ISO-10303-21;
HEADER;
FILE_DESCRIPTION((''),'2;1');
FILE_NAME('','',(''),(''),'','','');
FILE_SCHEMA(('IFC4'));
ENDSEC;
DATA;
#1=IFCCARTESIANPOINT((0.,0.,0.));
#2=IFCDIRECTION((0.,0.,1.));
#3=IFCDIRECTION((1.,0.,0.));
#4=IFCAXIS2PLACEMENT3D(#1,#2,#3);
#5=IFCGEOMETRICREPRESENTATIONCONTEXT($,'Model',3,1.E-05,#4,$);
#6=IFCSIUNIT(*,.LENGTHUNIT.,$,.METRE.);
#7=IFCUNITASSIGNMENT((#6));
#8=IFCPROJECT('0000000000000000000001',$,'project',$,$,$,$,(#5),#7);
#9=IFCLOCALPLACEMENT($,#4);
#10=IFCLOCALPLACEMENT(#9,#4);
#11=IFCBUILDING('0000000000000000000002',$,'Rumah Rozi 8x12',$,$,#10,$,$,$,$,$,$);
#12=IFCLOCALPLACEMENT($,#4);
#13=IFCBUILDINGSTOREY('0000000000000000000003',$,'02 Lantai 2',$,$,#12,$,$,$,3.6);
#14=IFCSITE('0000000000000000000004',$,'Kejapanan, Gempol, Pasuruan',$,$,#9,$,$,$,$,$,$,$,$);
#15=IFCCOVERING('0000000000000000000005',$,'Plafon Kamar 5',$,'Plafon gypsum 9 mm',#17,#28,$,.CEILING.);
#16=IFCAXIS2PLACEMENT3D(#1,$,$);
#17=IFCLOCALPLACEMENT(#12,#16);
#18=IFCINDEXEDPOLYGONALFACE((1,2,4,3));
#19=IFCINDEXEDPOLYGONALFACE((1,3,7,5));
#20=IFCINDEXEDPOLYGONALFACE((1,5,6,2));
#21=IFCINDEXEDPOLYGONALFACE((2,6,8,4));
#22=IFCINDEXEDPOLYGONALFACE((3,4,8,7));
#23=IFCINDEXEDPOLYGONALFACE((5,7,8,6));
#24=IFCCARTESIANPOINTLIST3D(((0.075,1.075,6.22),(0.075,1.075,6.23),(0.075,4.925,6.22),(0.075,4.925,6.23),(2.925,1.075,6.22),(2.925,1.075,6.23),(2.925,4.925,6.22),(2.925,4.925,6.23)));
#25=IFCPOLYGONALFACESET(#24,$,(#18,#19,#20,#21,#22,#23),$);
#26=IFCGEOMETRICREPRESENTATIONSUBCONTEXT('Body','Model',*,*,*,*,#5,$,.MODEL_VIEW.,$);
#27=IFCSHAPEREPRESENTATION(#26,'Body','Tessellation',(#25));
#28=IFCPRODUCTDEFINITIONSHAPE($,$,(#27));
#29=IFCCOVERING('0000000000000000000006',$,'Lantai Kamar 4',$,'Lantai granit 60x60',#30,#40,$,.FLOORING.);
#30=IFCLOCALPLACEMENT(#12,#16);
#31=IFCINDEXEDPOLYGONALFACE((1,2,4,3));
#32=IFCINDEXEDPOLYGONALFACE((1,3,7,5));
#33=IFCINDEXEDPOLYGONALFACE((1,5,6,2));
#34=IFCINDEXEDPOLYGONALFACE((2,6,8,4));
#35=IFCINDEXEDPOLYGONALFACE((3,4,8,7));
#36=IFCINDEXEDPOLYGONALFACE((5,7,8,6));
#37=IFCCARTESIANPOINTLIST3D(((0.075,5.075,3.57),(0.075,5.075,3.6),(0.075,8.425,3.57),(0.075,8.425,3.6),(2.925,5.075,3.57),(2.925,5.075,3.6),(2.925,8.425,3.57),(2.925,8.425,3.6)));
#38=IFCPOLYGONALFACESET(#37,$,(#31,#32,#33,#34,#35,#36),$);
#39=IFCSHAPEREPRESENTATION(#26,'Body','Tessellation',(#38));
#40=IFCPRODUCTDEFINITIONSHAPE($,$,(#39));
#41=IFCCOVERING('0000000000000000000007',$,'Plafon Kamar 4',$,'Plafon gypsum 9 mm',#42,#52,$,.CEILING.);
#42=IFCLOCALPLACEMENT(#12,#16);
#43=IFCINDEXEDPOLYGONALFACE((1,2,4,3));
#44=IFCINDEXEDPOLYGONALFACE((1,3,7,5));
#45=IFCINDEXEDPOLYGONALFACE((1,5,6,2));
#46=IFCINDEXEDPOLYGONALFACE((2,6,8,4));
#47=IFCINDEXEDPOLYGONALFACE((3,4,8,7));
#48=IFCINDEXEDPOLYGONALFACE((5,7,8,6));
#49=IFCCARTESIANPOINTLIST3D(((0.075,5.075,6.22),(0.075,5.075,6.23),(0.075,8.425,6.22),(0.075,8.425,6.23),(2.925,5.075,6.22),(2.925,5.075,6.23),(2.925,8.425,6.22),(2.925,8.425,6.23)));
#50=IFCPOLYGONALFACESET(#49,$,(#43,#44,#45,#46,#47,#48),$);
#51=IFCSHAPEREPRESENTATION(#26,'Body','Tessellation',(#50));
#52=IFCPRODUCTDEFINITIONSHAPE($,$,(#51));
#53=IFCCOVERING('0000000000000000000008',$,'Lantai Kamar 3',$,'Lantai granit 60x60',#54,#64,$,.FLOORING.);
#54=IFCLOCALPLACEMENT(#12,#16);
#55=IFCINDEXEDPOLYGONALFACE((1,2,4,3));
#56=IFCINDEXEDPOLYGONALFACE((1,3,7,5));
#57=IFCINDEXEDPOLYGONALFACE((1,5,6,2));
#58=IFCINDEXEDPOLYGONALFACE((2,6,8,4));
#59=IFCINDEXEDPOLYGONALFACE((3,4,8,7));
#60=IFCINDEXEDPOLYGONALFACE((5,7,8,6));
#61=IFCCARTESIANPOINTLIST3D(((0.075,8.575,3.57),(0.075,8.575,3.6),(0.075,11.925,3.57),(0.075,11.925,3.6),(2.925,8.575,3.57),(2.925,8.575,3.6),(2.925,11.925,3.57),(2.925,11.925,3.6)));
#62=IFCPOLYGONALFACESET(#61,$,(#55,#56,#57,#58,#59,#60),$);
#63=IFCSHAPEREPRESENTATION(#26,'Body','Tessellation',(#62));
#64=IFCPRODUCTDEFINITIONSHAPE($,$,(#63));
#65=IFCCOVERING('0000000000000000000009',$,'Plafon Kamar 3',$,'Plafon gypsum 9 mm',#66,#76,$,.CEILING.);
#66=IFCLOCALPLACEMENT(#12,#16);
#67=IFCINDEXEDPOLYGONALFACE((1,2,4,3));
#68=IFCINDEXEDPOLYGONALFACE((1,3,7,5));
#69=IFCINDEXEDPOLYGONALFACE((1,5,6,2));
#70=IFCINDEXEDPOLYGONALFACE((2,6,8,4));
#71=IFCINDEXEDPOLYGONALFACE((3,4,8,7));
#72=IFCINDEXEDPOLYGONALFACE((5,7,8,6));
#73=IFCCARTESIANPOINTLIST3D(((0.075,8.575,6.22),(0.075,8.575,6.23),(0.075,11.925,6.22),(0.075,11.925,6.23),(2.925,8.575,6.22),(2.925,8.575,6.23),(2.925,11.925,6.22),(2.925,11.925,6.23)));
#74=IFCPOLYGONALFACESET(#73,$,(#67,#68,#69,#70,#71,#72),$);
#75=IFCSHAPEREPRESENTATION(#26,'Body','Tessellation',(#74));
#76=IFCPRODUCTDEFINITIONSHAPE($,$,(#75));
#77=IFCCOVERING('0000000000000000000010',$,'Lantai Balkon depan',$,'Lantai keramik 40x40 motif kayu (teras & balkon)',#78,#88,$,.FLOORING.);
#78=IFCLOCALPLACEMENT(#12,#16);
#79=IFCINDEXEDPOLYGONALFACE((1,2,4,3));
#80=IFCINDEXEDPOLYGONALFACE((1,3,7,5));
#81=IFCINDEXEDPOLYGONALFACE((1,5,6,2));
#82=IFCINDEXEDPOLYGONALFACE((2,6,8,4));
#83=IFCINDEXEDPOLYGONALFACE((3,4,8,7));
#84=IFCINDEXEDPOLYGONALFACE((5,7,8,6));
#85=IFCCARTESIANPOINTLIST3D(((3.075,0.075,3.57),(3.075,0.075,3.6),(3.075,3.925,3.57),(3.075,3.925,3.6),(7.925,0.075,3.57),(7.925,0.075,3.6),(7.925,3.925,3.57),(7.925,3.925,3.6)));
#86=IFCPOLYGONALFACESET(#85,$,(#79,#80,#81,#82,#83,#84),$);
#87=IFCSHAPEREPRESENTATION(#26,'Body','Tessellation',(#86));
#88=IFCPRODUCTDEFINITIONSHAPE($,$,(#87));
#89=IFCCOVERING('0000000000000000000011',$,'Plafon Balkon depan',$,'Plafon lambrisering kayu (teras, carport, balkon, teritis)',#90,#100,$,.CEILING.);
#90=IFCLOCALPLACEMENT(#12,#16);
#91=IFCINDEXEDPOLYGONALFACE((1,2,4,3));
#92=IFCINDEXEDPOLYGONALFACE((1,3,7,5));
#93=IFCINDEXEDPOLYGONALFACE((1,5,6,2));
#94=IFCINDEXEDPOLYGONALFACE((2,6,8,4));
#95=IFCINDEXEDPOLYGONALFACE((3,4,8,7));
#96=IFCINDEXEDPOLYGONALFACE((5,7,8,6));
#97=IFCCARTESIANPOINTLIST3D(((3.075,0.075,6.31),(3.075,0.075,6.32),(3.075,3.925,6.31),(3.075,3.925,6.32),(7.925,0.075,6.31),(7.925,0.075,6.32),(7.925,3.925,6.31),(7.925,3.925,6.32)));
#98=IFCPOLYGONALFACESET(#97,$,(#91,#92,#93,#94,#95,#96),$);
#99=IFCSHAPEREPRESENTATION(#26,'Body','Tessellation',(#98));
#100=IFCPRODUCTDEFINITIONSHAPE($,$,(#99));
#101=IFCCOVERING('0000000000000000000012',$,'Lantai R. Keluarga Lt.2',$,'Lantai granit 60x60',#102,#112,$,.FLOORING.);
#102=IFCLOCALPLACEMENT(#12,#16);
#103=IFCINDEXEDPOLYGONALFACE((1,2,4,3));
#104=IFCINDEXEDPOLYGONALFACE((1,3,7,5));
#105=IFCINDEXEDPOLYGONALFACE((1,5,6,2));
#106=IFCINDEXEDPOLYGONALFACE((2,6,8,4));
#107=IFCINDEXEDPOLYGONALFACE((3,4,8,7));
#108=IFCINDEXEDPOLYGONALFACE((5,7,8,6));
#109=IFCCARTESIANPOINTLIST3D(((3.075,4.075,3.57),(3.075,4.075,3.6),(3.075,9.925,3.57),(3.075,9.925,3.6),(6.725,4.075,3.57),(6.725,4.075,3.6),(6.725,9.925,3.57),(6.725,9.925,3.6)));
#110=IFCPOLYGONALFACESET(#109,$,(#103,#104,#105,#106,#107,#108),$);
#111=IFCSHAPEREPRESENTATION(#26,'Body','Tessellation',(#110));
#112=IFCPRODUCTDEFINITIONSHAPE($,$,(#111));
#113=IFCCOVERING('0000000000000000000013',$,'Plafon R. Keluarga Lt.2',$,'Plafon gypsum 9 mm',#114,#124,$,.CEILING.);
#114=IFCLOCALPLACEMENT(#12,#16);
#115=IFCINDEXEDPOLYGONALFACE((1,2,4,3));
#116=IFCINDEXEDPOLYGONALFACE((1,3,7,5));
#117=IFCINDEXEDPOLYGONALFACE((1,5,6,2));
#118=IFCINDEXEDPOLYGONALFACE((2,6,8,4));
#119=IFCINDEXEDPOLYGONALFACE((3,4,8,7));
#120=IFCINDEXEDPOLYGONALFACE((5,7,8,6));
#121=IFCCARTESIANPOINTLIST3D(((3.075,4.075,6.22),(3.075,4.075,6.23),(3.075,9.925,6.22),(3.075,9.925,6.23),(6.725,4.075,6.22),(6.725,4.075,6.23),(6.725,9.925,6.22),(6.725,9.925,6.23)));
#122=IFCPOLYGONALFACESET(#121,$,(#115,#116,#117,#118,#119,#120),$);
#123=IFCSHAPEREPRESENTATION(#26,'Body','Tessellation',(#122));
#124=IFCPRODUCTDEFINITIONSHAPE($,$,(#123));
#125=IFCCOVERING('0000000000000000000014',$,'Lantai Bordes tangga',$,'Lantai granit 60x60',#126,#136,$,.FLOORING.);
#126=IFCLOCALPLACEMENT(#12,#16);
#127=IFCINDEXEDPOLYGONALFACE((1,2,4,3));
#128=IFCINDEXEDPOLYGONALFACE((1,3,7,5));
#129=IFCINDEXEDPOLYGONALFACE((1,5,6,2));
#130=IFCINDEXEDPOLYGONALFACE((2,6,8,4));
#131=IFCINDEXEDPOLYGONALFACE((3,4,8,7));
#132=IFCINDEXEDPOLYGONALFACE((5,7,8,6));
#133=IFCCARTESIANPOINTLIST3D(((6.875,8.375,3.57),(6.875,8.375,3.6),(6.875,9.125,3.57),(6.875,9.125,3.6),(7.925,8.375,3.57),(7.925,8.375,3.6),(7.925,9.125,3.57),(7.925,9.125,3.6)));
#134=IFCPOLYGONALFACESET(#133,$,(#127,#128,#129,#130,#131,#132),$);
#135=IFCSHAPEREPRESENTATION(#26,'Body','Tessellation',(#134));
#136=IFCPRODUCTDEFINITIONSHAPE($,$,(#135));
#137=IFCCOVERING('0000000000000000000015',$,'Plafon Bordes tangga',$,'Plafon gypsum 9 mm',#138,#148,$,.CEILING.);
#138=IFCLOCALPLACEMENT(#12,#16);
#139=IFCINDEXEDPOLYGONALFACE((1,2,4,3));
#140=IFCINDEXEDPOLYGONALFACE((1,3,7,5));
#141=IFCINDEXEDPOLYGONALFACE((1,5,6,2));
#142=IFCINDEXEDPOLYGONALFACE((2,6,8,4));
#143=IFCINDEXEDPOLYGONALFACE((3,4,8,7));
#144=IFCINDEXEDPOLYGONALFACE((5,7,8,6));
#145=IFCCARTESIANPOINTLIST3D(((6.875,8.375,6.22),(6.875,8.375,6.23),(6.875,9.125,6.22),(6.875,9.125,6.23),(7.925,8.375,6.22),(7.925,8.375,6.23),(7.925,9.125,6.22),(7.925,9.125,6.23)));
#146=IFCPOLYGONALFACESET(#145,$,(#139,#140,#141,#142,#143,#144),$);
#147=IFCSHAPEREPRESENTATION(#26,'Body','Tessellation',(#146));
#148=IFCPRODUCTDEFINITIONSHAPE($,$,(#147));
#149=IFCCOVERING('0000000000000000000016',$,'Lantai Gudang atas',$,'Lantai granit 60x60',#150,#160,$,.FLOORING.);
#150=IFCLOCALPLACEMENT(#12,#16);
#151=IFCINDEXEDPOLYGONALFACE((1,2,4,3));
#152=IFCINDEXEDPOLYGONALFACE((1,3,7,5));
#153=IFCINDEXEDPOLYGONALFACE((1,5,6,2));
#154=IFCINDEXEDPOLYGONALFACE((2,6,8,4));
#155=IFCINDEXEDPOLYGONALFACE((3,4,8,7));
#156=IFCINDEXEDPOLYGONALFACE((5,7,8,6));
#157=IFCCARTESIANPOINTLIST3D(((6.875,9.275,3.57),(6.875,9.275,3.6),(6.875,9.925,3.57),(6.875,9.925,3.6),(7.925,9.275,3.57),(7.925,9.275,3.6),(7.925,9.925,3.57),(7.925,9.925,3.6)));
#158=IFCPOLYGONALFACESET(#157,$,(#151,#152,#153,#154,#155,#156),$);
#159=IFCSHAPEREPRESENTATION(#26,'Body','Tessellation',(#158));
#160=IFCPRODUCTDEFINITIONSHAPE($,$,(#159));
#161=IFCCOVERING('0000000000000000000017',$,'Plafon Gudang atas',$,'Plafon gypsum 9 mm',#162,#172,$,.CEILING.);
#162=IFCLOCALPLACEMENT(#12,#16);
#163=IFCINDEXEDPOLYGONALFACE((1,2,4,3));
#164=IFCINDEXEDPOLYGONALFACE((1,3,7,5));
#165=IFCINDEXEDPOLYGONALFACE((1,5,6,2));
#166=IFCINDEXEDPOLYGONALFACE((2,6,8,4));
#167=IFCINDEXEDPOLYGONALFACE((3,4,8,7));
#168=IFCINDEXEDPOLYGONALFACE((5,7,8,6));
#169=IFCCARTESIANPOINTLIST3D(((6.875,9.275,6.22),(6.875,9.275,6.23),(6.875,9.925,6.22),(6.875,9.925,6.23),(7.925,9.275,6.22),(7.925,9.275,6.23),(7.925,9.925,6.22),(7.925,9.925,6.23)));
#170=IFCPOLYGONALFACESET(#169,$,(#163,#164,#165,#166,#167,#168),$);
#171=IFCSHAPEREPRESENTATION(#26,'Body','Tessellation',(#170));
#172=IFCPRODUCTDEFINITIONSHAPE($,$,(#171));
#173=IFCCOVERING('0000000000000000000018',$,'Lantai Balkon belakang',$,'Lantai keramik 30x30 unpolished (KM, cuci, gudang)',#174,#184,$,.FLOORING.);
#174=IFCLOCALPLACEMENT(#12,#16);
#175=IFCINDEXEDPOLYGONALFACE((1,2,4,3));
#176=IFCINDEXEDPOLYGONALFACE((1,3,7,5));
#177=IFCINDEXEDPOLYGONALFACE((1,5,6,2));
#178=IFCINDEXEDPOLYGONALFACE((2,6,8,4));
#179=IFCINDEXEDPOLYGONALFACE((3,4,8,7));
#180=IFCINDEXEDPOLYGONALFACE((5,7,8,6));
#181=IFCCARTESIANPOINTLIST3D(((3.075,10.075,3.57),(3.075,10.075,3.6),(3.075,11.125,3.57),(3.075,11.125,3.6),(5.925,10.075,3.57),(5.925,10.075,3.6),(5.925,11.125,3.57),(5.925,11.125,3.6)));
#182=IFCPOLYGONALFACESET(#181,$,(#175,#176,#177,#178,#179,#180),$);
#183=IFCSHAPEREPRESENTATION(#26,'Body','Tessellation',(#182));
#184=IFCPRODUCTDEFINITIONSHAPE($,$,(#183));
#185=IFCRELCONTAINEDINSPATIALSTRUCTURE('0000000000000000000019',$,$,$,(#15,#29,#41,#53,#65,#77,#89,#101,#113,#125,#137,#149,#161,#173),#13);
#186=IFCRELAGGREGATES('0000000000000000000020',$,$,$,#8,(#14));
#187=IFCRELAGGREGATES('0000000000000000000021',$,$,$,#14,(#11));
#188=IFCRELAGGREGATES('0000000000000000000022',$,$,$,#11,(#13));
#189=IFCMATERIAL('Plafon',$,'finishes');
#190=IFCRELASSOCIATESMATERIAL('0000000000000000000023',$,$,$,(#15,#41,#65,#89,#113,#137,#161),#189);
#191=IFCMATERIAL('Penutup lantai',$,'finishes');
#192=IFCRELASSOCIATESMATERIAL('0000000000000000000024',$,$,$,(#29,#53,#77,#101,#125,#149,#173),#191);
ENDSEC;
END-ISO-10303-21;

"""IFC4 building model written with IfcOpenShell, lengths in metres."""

from ifc_helpers import new_model, si_unit, frame, origin_with_axes, place, context, subcontext, project, spatial, line, indexed_curve, outline, extrude, material, element, save


model = new_model("IFC4")

# Units and contexts
model_context = context("Model", 3, precision=1e-05, world=origin_with_axes())
body_context = subcontext(model_context, "Body", "Model", "MODEL_VIEW")
ifc_project = project(units=[si_unit("LENGTHUNIT", "METRE")], contexts=[model_context])

# Site, building, storey
site_placement = place(None, origin_with_axes())
site = spatial("IfcSite", under=ifc_project, at=site_placement, Name="Kejapanan, Gempol, Pasuruan")
building_placement = place(site_placement, origin_with_axes())
building = spatial("IfcBuilding", under=site, at=building_placement, Name="Rumah Rozi 8x12")
storey_placement = place(None, origin_with_axes())
storey = spatial("IfcBuildingStorey", under=building, at=storey_placement, Name="02 Lantai 2", Elevation=3.6)

# Coverings
ifc_material_1 = material(Name="Plafon", Category="finishes")
covering_1_placement = place(storey_placement, origin_with_axes())
element("IfcCovering", 1, at=covering_1_placement, inside=storey, material=ifc_material_1, Name="Plafon Kamar 5", ObjectType="Plafon gypsum 9 mm", PredefinedType="CEILING", context=body_context, shape_type="SweptSolid", body=[
    extrude(outline(indexed_curve([(0.075, 1.075), (2.925, 1.075), (2.925, 4.925), (0.075, 4.925)], segments=[line(1, 2, 3, 4, 1)])), frame((0.0, 0.0, 6.22), z_axis=(0.0, 0.0, 1.0), x_axis=(1.0, 0.0, 0.0)), (0.0, 0.0, 1.0), 0.01),
])
ifc_material_2 = material(Name="Penutup lantai", Category="finishes")
covering_2_placement = place(storey_placement, origin_with_axes())
element("IfcCovering", 2, at=covering_2_placement, inside=storey, material=ifc_material_2, Name="Lantai Kamar 4", ObjectType="Lantai granit 60x60", PredefinedType="FLOORING", context=body_context, shape_type="SweptSolid", body=[
    extrude(outline(indexed_curve([(0.075, 5.075), (2.925, 5.075), (2.925, 8.425), (0.075, 8.425)], segments=[line(1, 2, 3, 4, 1)])), frame((0.0, 0.0, 3.57), z_axis=(0.0, 0.0, 1.0), x_axis=(1.0, 0.0, 0.0)), (0.0, 0.0, 1.0), 0.03),
])
covering_3_placement = place(storey_placement, origin_with_axes())
element("IfcCovering", 3, at=covering_3_placement, inside=storey, material=ifc_material_1, Name="Plafon Kamar 4", ObjectType="Plafon gypsum 9 mm", PredefinedType="CEILING", context=body_context, shape_type="SweptSolid", body=[
    extrude(outline(indexed_curve([(0.075, 5.075), (2.925, 5.075), (2.925, 8.425), (0.075, 8.425)], segments=[line(1, 2, 3, 4, 1)])), frame((0.0, 0.0, 6.22), z_axis=(0.0, 0.0, 1.0), x_axis=(1.0, 0.0, 0.0)), (0.0, 0.0, 1.0), 0.01),
])
covering_4_placement = place(storey_placement, origin_with_axes())
element("IfcCovering", 4, at=covering_4_placement, inside=storey, material=ifc_material_2, Name="Lantai Kamar 3", ObjectType="Lantai granit 60x60", PredefinedType="FLOORING", context=body_context, shape_type="SweptSolid", body=[
    extrude(outline(indexed_curve([(0.075, 8.575), (2.925, 8.575), (2.925, 11.925), (0.075, 11.925)], segments=[line(1, 2, 3, 4, 1)])), frame((0.0, 0.0, 3.57), z_axis=(0.0, 0.0, 1.0), x_axis=(1.0, 0.0, 0.0)), (0.0, 0.0, 1.0), 0.03),
])
covering_5_placement = place(storey_placement, origin_with_axes())
element("IfcCovering", 5, at=covering_5_placement, inside=storey, material=ifc_material_1, Name="Plafon Kamar 3", ObjectType="Plafon gypsum 9 mm", PredefinedType="CEILING", context=body_context, shape_type="SweptSolid", body=[
    extrude(outline(indexed_curve([(0.075, 8.575), (2.925, 8.575), (2.925, 11.925), (0.075, 11.925)], segments=[line(1, 2, 3, 4, 1)])), frame((0.0, 0.0, 6.22), z_axis=(0.0, 0.0, 1.0), x_axis=(1.0, 0.0, 0.0)), (0.0, 0.0, 1.0), 0.01),
])
covering_6_placement = place(storey_placement, origin_with_axes())
element("IfcCovering", 6, at=covering_6_placement, inside=storey, material=ifc_material_2, Name="Lantai Balkon depan", ObjectType="Lantai keramik 40x40 motif kayu (teras & balkon)", PredefinedType="FLOORING", context=body_context, shape_type="SweptSolid", body=[
    extrude(outline(indexed_curve([(3.075, 0.075), (7.925, 0.075), (7.925, 3.925), (3.075, 3.925)], segments=[line(1, 2, 3, 4, 1)])), frame((0.0, 0.0, 3.57), z_axis=(0.0, 0.0, 1.0), x_axis=(1.0, 0.0, 0.0)), (0.0, 0.0, 1.0), 0.03),
])
covering_7_placement = place(storey_placement, origin_with_axes())
element("IfcCovering", 7, at=covering_7_placement, inside=storey, material=ifc_material_1, Name="Plafon Balkon depan", ObjectType="Plafon lambrisering kayu (teras, carport, balkon, teritis)", PredefinedType="CEILING", context=body_context, shape_type="SweptSolid", body=[
    extrude(outline(indexed_curve([(3.075, 0.075), (7.925, 0.075), (7.925, 3.925), (3.075, 3.925)], segments=[line(1, 2, 3, 4, 1)])), frame((0.0, 0.0, 6.31), z_axis=(0.0, 0.0, 1.0), x_axis=(1.0, 0.0, 0.0)), (0.0, 0.0, 1.0), 0.01),
])
covering_8_placement = place(storey_placement, origin_with_axes())
element("IfcCovering", 8, at=covering_8_placement, inside=storey, material=ifc_material_2, Name="Lantai R. Keluarga Lt.2", ObjectType="Lantai granit 60x60", PredefinedType="FLOORING", context=body_context, shape_type="SweptSolid", body=[
    extrude(outline(indexed_curve([(3.075, 4.075), (6.725, 4.075), (6.725, 9.925), (3.075, 9.925)], segments=[line(1, 2, 3, 4, 1)])), frame((0.0, 0.0, 3.57), z_axis=(0.0, 0.0, 1.0), x_axis=(1.0, 0.0, 0.0)), (0.0, 0.0, 1.0), 0.03),
])
covering_9_placement = place(storey_placement, origin_with_axes())
element("IfcCovering", 9, at=covering_9_placement, inside=storey, material=ifc_material_1, Name="Plafon R. Keluarga Lt.2", ObjectType="Plafon gypsum 9 mm", PredefinedType="CEILING", context=body_context, shape_type="SweptSolid", body=[
    extrude(outline(indexed_curve([(3.075, 4.075), (6.725, 4.075), (6.725, 9.925), (3.075, 9.925)], segments=[line(1, 2, 3, 4, 1)])), frame((0.0, 0.0, 6.22), z_axis=(0.0, 0.0, 1.0), x_axis=(1.0, 0.0, 0.0)), (0.0, 0.0, 1.0), 0.01),
])
covering_10_placement = place(storey_placement, origin_with_axes())
element("IfcCovering", 10, at=covering_10_placement, inside=storey, material=ifc_material_2, Name="Lantai Bordes tangga", ObjectType="Lantai granit 60x60", PredefinedType="FLOORING", context=body_context, shape_type="SweptSolid", body=[
    extrude(outline(indexed_curve([(6.875, 8.375), (7.925, 8.375), (7.925, 9.125), (6.875, 9.125)], segments=[line(1, 2, 3, 4, 1)])), frame((0.0, 0.0, 3.57), z_axis=(0.0, 0.0, 1.0), x_axis=(1.0, 0.0, 0.0)), (0.0, 0.0, 1.0), 0.03),
])
covering_11_placement = place(storey_placement, origin_with_axes())
element("IfcCovering", 11, at=covering_11_placement, inside=storey, material=ifc_material_1, Name="Plafon Bordes tangga", ObjectType="Plafon gypsum 9 mm", PredefinedType="CEILING", context=body_context, shape_type="SweptSolid", body=[
    extrude(outline(indexed_curve([(6.875, 8.375), (7.925, 8.375), (7.925, 9.125), (6.875, 9.125)], segments=[line(1, 2, 3, 4, 1)])), frame((0.0, 0.0, 6.22), z_axis=(0.0, 0.0, 1.0), x_axis=(1.0, 0.0, 0.0)), (0.0, 0.0, 1.0), 0.01),
])
covering_12_placement = place(storey_placement, origin_with_axes())
element("IfcCovering", 12, at=covering_12_placement, inside=storey, material=ifc_material_2, Name="Lantai Gudang atas", ObjectType="Lantai granit 60x60", PredefinedType="FLOORING", context=body_context, shape_type="SweptSolid", body=[
    extrude(outline(indexed_curve([(6.875, 9.275), (7.925, 9.275), (7.925, 9.925), (6.875, 9.925)], segments=[line(1, 2, 3, 4, 1)])), frame((0.0, 0.0, 3.57), z_axis=(0.0, 0.0, 1.0), x_axis=(1.0, 0.0, 0.0)), (0.0, 0.0, 1.0), 0.03),
])
covering_13_placement = place(storey_placement, origin_with_axes())
element("IfcCovering", 13, at=covering_13_placement, inside=storey, material=ifc_material_1, Name="Plafon Gudang atas", ObjectType="Plafon gypsum 9 mm", PredefinedType="CEILING", context=body_context, shape_type="SweptSolid", body=[
    extrude(outline(indexed_curve([(6.875, 9.275), (7.925, 9.275), (7.925, 9.925), (6.875, 9.925)], segments=[line(1, 2, 3, 4, 1)])), frame((0.0, 0.0, 6.22), z_axis=(0.0, 0.0, 1.0), x_axis=(1.0, 0.0, 0.0)), (0.0, 0.0, 1.0), 0.01),
])
covering_14_placement = place(storey_placement, origin_with_axes())
element("IfcCovering", 14, at=covering_14_placement, inside=storey, material=ifc_material_2, Name="Lantai Balkon belakang", ObjectType="Lantai keramik 30x30 unpolished (KM, cuci, gudang)", PredefinedType="FLOORING", context=body_context, shape_type="SweptSolid", body=[
    extrude(outline(indexed_curve([(3.075, 10.075), (5.925, 10.075), (5.925, 11.125), (3.075, 11.125)], segments=[line(1, 2, 3, 4, 1)])), frame((0.0, 0.0, 3.57), z_axis=(0.0, 0.0, 1.0), x_axis=(1.0, 0.0, 0.0)), (0.0, 0.0, 1.0), 0.03),
])

save(model, "model.ifc")
